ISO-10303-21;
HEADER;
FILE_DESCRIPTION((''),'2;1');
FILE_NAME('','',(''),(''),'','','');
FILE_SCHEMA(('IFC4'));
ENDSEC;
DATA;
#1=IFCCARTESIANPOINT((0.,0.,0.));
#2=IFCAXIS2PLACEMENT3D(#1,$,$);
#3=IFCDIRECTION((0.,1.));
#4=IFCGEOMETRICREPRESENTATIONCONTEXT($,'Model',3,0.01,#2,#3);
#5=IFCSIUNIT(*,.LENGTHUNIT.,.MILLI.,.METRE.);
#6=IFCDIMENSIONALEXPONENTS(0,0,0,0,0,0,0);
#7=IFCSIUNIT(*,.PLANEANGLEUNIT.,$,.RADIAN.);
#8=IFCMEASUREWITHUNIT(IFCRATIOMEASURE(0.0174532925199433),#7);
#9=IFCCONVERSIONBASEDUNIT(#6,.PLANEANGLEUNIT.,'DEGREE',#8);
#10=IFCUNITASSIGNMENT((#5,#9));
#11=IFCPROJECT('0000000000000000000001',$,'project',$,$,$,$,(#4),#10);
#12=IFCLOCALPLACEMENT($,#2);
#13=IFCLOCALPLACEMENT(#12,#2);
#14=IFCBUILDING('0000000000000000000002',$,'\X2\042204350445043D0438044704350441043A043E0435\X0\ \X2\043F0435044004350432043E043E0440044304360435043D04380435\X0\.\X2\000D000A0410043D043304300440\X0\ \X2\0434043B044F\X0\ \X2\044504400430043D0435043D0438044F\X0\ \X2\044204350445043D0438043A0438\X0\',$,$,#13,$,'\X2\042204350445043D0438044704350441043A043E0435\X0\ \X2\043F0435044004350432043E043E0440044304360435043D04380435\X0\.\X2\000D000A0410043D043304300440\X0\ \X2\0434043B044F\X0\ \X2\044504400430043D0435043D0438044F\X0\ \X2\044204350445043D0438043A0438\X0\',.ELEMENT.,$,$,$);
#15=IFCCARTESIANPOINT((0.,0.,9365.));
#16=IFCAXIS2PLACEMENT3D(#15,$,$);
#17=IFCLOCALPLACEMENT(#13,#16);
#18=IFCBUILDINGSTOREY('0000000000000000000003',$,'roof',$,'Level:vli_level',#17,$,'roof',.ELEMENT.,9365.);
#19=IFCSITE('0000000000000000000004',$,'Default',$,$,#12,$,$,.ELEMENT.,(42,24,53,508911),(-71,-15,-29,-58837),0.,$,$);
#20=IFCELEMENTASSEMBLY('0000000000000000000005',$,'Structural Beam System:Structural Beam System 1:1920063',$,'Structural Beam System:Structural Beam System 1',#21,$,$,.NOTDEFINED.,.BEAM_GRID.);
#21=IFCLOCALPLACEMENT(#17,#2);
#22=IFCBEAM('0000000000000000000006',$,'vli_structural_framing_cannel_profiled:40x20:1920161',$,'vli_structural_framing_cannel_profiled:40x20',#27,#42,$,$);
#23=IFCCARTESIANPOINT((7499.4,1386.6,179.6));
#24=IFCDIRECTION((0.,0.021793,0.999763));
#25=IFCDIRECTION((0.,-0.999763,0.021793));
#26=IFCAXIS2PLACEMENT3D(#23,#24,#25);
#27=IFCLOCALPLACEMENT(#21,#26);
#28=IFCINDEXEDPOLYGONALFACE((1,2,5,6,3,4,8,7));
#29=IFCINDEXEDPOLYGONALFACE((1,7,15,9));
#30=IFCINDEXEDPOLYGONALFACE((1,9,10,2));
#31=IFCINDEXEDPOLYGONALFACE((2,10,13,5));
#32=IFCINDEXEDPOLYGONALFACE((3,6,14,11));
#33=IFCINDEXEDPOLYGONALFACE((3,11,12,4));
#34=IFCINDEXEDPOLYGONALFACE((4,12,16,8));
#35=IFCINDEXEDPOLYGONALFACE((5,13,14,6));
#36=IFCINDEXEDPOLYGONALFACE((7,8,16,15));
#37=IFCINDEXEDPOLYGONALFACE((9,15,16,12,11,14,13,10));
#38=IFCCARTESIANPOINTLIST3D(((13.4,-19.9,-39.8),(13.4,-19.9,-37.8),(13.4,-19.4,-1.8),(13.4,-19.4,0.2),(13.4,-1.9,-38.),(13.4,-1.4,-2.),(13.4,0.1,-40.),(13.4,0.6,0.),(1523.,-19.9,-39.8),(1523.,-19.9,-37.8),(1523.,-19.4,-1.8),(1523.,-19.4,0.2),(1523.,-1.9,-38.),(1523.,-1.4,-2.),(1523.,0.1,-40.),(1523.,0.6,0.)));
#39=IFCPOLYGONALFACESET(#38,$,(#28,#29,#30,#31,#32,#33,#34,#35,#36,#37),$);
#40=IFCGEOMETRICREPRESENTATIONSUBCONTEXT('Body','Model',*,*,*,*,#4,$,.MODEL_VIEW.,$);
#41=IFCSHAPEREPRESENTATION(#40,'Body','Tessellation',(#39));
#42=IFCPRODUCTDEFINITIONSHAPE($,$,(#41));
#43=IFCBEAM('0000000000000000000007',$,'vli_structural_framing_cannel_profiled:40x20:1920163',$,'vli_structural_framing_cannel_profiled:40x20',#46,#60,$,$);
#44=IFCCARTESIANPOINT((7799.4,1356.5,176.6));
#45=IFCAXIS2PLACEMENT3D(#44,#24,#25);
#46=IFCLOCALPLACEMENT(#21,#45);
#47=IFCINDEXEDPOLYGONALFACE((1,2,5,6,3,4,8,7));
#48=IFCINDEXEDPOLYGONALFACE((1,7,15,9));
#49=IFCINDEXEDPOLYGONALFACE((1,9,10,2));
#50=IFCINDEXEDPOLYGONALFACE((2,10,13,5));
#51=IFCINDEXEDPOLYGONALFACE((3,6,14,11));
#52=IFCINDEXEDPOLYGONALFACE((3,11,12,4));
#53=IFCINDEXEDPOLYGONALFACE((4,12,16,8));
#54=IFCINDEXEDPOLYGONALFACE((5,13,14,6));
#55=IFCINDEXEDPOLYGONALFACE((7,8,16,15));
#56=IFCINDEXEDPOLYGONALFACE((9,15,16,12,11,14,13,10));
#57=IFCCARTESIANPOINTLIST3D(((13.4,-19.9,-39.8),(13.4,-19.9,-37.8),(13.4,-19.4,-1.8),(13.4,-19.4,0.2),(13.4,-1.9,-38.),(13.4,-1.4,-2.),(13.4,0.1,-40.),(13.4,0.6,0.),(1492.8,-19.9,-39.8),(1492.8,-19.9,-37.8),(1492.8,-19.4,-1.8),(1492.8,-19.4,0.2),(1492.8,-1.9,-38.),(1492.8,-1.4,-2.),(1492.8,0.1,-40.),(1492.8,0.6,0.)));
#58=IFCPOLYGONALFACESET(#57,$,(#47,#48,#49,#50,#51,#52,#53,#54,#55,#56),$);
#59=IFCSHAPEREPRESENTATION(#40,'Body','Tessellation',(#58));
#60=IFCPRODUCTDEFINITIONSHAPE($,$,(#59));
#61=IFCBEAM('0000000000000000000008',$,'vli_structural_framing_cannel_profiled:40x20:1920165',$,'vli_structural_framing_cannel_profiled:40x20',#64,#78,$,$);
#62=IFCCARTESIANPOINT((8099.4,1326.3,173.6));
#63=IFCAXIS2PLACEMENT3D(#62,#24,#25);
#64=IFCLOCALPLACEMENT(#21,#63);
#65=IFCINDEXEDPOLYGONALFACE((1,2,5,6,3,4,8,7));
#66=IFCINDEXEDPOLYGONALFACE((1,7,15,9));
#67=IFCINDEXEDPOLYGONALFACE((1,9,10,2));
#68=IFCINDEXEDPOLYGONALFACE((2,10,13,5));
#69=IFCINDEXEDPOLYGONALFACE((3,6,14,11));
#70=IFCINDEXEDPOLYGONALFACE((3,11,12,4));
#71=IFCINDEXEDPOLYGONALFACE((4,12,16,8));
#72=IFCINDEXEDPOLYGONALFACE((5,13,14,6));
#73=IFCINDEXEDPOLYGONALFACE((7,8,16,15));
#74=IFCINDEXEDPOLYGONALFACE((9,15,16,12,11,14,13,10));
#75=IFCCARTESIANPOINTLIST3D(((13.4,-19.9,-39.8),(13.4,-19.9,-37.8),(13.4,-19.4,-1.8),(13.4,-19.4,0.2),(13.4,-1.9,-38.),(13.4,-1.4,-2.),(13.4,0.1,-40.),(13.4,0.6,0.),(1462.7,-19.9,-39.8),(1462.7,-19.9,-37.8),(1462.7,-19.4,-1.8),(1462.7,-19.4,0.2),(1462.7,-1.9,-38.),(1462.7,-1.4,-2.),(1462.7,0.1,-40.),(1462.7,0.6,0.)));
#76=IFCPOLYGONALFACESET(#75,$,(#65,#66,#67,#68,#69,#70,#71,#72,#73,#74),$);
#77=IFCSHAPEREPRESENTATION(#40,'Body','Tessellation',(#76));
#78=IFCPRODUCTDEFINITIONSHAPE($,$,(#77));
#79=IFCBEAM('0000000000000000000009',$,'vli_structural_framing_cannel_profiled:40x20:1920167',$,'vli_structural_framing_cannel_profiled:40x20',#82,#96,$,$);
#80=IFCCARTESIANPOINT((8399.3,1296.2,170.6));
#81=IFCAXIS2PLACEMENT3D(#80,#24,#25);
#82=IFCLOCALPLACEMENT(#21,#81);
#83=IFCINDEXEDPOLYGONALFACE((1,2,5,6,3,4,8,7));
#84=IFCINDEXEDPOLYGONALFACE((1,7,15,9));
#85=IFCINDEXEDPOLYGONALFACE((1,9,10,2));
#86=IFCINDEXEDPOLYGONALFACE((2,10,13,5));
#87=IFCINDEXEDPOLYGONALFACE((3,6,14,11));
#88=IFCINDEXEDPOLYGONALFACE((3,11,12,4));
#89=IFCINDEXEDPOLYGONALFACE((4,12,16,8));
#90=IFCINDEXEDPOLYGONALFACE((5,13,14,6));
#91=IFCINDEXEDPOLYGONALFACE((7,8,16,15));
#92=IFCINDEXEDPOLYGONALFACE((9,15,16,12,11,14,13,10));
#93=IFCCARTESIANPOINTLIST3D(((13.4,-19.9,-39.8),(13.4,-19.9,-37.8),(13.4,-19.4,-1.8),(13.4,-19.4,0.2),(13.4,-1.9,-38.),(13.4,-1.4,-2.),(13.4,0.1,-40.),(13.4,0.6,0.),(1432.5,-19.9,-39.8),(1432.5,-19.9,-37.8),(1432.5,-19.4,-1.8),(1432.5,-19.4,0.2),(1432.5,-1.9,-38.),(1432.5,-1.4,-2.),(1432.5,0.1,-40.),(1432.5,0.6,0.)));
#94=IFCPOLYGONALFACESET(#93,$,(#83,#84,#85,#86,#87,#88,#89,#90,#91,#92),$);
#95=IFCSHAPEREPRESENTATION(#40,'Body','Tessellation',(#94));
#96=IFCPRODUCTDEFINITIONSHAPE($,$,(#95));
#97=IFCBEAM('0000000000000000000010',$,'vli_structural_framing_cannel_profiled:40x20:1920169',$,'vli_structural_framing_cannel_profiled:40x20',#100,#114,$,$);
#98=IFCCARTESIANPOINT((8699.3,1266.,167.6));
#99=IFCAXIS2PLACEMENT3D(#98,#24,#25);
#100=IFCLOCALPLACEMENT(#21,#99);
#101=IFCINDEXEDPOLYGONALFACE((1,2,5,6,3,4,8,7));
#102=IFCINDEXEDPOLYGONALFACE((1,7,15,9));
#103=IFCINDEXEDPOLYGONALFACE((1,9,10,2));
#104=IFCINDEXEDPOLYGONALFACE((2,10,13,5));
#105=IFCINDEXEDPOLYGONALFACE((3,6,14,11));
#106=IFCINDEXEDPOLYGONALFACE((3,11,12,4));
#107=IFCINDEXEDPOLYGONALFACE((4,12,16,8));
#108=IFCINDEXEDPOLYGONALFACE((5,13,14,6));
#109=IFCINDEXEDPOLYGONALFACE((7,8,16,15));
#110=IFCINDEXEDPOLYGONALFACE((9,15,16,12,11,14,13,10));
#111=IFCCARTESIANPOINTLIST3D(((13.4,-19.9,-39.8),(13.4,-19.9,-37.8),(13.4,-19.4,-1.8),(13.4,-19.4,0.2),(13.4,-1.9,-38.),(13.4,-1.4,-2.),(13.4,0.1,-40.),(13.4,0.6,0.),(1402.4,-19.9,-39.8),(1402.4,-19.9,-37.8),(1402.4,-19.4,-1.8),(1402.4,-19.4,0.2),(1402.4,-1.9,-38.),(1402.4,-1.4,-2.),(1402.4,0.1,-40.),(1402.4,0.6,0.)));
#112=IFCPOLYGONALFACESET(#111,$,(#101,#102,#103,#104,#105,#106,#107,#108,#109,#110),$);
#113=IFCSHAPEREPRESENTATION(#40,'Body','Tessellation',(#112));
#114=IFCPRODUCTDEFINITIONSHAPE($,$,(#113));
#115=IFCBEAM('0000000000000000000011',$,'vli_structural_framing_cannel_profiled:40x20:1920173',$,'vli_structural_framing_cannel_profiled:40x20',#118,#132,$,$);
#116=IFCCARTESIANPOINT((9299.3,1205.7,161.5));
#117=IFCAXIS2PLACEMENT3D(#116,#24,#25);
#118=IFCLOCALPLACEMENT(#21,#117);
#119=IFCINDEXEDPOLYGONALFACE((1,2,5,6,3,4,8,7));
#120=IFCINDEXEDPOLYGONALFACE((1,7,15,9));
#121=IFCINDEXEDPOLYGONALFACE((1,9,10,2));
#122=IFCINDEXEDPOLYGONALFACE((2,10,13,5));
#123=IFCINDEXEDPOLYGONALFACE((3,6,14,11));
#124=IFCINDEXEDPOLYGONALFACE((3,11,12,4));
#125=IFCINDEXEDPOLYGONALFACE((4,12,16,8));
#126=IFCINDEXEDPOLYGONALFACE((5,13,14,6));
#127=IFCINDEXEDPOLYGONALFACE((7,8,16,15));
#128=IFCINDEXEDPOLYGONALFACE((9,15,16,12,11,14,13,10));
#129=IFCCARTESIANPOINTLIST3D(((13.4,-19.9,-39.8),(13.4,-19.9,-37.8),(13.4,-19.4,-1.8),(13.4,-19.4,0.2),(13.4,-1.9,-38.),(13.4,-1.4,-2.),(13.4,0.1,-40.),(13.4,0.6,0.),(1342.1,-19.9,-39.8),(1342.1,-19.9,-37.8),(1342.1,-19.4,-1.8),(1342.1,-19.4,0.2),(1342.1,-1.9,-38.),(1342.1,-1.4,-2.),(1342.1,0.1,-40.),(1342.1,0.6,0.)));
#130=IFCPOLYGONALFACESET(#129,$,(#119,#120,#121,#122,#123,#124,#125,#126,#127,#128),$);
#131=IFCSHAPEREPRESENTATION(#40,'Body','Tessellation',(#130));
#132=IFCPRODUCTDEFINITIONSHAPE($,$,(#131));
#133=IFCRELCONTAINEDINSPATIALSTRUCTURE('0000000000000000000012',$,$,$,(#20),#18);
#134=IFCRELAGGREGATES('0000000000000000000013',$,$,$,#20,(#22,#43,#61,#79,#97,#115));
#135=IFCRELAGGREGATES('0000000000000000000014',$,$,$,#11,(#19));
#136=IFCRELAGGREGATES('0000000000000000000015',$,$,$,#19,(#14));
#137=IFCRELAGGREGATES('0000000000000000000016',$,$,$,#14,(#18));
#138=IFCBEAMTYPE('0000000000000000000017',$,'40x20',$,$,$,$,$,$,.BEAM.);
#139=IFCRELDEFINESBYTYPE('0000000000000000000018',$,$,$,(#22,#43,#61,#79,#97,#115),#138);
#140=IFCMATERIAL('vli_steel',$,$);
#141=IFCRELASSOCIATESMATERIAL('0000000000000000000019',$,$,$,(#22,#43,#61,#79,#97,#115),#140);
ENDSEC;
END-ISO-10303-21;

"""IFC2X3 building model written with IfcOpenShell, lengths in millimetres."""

from ifc_helpers import new_model, entity, si_unit, converted_unit, direction, frame, origin, place, context, subcontext, project, spatial, polyline, outline, extrude, material, type_object, element, aggregate, save


model = new_model("IFC2X3")

# Units and contexts
model_context = context("Model", 3, precision=0.01, world=origin(), true_north=direction((0.0, 1.0)))
body_context = subcontext(model_context, "Body", "Model", "MODEL_VIEW")
ifc_project = project(units=[si_unit("LENGTHUNIT", "METRE", prefix="MILLI"), converted_unit("PLANEANGLEUNIT", "DEGREE", entity("IfcRatioMeasure", 0.0174532925199433), si_unit("PLANEANGLEUNIT", "RADIAN"), dimensions=[0, 0, 0, 0, 0, 0, 0])], contexts=[model_context])

# Site, building, storey
site_placement = place(None, origin())
site = spatial("IfcSite", under=ifc_project, at=site_placement, Name="Default", CompositionType="ELEMENT", RefLatitude=(42, 24, 53, 508911), RefLongitude=(-71, -15, -29, -58837), RefElevation=0.0)
building_placement = place(site_placement, origin())
building = spatial("IfcBuilding", under=site, at=building_placement, Name="Техническое перевооружение.\r\nАнгар для хранения техники", LongName="Техническое перевооружение.\r\nАнгар для хранения техники", CompositionType="ELEMENT")
storey_placement = place(building_placement, frame((0.0, 0.0, 9365.0)))
storey = spatial("IfcBuildingStorey", under=building, at=storey_placement, Name="roof", ObjectType="Level:vli_level", LongName="roof", CompositionType="ELEMENT", Elevation=9365.0)

# Element assembly, beams
ifc_material = material(Name="vli_steel")
beam_type = type_object("IfcBeamType", Name="40x20", PredefinedType="BEAM")
assembly_1_placement = place(storey_placement, origin())
assembly_1 = element("IfcElementAssembly", 1, at=assembly_1_placement, inside=storey, Name="Structural Beam System:Structural Beam System 1:1920063", ObjectType="Structural Beam System:Structural Beam System 1", AssemblyPlace="NOTDEFINED", PredefinedType="BEAM_GRID")
beam_1_placement = place(assembly_1_placement, frame((7499.4, 1386.6, 179.6), z_axis=(0.0, 0.021793, 0.999763), x_axis=(0.0, -0.999763, 0.021793)))
beam_1 = element("IfcBeam", 2, at=beam_1_placement, type_object=beam_type, material=ifc_material, Name="vli_structural_framing_cannel_profiled:40x20:1920161", ObjectType="vli_structural_framing_cannel_profiled:40x20", context=body_context, shape_type="SweptSolid", body=[
    extrude(outline(polyline([(-10.5, -20.0), (9.5, -20.0), (9.5, -18.0), (-8.5, -18.0), (-8.5, 18.0), (9.5, 18.0), (9.5, 20.0), (-10.5, 20.0), (-10.5, -20.0)])), frame((13.4, -10.1, -19.9), z_axis=(1.0, 0.0, 0.0), x_axis=(0.0, -0.999925, 0.012237)), (0.0, 0.0, 1.0), 1509.6),
])
beam_2_placement = place(assembly_1_placement, frame((7799.4, 1356.5, 176.6), z_axis=(0.0, 0.021793, 0.999763), x_axis=(0.0, -0.999763, 0.021793)))
beam_2 = element("IfcBeam", 3, at=beam_2_placement, type_object=beam_type, material=ifc_material, Name="vli_structural_framing_cannel_profiled:40x20:1920163", ObjectType="vli_structural_framing_cannel_profiled:40x20", context=body_context, shape_type="SweptSolid", body=[
    extrude(outline(polyline([(-10.5, -20.0), (9.5, -20.0), (9.5, -18.0), (-8.5, -18.0), (-8.5, 18.0), (9.5, 18.0), (9.5, 20.0), (-10.5, 20.0), (-10.5, -20.0)])), frame((13.4, -10.1, -19.9), z_axis=(1.0, 0.0, 0.0), x_axis=(0.0, -0.999925, 0.012237)), (0.0, 0.0, 1.0), 1479.5),
])
beam_3_placement = place(assembly_1_placement, frame((8099.4, 1326.3, 173.6), z_axis=(0.0, 0.021793, 0.999763), x_axis=(0.0, -0.999763, 0.021793)))
beam_3 = element("IfcBeam", 4, at=beam_3_placement, type_object=beam_type, material=ifc_material, Name="vli_structural_framing_cannel_profiled:40x20:1920165", ObjectType="vli_structural_framing_cannel_profiled:40x20", context=body_context, shape_type="SweptSolid", body=[
    extrude(outline(polyline([(-10.5, -20.0), (9.5, -20.0), (9.5, -18.0), (-8.5, -18.0), (-8.5, 18.0), (9.5, 18.0), (9.5, 20.0), (-10.5, 20.0), (-10.5, -20.0)])), frame((13.4, -10.1, -19.9), z_axis=(1.0, 0.0, 0.0), x_axis=(0.0, -0.999925, 0.012237)), (0.0, 0.0, 1.0), 1449.3),
])
beam_4_placement = place(assembly_1_placement, frame((8399.3, 1296.2, 170.6), z_axis=(0.0, 0.021793, 0.999763), x_axis=(0.0, -0.999763, 0.021793)))
beam_4 = element("IfcBeam", 5, at=beam_4_placement, type_object=beam_type, material=ifc_material, Name="vli_structural_framing_cannel_profiled:40x20:1920167", ObjectType="vli_structural_framing_cannel_profiled:40x20", context=body_context, shape_type="SweptSolid", body=[
    extrude(outline(polyline([(-10.5, -20.0), (9.5, -20.0), (9.5, -18.0), (-8.5, -18.0), (-8.5, 18.0), (9.5, 18.0), (9.5, 20.0), (-10.5, 20.0), (-10.5, -20.0)])), frame((13.4, -10.1, -19.9), z_axis=(1.0, 0.0, 0.0), x_axis=(0.0, -0.999925, 0.012237)), (0.0, 0.0, 1.0), 1419.2),
])
beam_5_placement = place(assembly_1_placement, frame((8699.3, 1266.0, 167.6), z_axis=(0.0, 0.021793, 0.999763), x_axis=(0.0, -0.999763, 0.021793)))
beam_5 = element("IfcBeam", 6, at=beam_5_placement, type_object=beam_type, material=ifc_material, Name="vli_structural_framing_cannel_profiled:40x20:1920169", ObjectType="vli_structural_framing_cannel_profiled:40x20", context=body_context, shape_type="SweptSolid", body=[
    extrude(outline(polyline([(-10.5, -20.0), (9.5, -20.0), (9.5, -18.0), (-8.5, -18.0), (-8.5, 18.0), (9.5, 18.0), (9.5, 20.0), (-10.5, 20.0), (-10.5, -20.0)])), frame((13.4, -10.1, -19.9), z_axis=(1.0, 0.0, 0.0), x_axis=(0.0, -0.999925, 0.012237)), (0.0, 0.0, 1.0), 1389.0),
])
beam_6_placement = place(assembly_1_placement, frame((9299.3, 1205.7, 161.5), z_axis=(0.0, 0.021793, 0.999763), x_axis=(0.0, -0.999763, 0.021793)))
beam_6 = element("IfcBeam", 7, at=beam_6_placement, type_object=beam_type, material=ifc_material, Name="vli_structural_framing_cannel_profiled:40x20:1920173", ObjectType="vli_structural_framing_cannel_profiled:40x20", context=body_context, shape_type="SweptSolid", body=[
    extrude(outline(polyline([(-10.5, -20.0), (9.5, -20.0), (9.5, -18.0), (-8.5, -18.0), (-8.5, 18.0), (9.5, 18.0), (9.5, 20.0), (-10.5, 20.0), (-10.5, -20.0)])), frame((13.4, -10.1, -19.9), z_axis=(1.0, 0.0, 0.0), x_axis=(0.0, -0.999925, 0.012237)), (0.0, 0.0, 1.0), 1328.7),
])
aggregate(assembly_1, [beam_1, beam_2, beam_3, beam_4, beam_5, beam_6])

save(model, "model.ifc")
